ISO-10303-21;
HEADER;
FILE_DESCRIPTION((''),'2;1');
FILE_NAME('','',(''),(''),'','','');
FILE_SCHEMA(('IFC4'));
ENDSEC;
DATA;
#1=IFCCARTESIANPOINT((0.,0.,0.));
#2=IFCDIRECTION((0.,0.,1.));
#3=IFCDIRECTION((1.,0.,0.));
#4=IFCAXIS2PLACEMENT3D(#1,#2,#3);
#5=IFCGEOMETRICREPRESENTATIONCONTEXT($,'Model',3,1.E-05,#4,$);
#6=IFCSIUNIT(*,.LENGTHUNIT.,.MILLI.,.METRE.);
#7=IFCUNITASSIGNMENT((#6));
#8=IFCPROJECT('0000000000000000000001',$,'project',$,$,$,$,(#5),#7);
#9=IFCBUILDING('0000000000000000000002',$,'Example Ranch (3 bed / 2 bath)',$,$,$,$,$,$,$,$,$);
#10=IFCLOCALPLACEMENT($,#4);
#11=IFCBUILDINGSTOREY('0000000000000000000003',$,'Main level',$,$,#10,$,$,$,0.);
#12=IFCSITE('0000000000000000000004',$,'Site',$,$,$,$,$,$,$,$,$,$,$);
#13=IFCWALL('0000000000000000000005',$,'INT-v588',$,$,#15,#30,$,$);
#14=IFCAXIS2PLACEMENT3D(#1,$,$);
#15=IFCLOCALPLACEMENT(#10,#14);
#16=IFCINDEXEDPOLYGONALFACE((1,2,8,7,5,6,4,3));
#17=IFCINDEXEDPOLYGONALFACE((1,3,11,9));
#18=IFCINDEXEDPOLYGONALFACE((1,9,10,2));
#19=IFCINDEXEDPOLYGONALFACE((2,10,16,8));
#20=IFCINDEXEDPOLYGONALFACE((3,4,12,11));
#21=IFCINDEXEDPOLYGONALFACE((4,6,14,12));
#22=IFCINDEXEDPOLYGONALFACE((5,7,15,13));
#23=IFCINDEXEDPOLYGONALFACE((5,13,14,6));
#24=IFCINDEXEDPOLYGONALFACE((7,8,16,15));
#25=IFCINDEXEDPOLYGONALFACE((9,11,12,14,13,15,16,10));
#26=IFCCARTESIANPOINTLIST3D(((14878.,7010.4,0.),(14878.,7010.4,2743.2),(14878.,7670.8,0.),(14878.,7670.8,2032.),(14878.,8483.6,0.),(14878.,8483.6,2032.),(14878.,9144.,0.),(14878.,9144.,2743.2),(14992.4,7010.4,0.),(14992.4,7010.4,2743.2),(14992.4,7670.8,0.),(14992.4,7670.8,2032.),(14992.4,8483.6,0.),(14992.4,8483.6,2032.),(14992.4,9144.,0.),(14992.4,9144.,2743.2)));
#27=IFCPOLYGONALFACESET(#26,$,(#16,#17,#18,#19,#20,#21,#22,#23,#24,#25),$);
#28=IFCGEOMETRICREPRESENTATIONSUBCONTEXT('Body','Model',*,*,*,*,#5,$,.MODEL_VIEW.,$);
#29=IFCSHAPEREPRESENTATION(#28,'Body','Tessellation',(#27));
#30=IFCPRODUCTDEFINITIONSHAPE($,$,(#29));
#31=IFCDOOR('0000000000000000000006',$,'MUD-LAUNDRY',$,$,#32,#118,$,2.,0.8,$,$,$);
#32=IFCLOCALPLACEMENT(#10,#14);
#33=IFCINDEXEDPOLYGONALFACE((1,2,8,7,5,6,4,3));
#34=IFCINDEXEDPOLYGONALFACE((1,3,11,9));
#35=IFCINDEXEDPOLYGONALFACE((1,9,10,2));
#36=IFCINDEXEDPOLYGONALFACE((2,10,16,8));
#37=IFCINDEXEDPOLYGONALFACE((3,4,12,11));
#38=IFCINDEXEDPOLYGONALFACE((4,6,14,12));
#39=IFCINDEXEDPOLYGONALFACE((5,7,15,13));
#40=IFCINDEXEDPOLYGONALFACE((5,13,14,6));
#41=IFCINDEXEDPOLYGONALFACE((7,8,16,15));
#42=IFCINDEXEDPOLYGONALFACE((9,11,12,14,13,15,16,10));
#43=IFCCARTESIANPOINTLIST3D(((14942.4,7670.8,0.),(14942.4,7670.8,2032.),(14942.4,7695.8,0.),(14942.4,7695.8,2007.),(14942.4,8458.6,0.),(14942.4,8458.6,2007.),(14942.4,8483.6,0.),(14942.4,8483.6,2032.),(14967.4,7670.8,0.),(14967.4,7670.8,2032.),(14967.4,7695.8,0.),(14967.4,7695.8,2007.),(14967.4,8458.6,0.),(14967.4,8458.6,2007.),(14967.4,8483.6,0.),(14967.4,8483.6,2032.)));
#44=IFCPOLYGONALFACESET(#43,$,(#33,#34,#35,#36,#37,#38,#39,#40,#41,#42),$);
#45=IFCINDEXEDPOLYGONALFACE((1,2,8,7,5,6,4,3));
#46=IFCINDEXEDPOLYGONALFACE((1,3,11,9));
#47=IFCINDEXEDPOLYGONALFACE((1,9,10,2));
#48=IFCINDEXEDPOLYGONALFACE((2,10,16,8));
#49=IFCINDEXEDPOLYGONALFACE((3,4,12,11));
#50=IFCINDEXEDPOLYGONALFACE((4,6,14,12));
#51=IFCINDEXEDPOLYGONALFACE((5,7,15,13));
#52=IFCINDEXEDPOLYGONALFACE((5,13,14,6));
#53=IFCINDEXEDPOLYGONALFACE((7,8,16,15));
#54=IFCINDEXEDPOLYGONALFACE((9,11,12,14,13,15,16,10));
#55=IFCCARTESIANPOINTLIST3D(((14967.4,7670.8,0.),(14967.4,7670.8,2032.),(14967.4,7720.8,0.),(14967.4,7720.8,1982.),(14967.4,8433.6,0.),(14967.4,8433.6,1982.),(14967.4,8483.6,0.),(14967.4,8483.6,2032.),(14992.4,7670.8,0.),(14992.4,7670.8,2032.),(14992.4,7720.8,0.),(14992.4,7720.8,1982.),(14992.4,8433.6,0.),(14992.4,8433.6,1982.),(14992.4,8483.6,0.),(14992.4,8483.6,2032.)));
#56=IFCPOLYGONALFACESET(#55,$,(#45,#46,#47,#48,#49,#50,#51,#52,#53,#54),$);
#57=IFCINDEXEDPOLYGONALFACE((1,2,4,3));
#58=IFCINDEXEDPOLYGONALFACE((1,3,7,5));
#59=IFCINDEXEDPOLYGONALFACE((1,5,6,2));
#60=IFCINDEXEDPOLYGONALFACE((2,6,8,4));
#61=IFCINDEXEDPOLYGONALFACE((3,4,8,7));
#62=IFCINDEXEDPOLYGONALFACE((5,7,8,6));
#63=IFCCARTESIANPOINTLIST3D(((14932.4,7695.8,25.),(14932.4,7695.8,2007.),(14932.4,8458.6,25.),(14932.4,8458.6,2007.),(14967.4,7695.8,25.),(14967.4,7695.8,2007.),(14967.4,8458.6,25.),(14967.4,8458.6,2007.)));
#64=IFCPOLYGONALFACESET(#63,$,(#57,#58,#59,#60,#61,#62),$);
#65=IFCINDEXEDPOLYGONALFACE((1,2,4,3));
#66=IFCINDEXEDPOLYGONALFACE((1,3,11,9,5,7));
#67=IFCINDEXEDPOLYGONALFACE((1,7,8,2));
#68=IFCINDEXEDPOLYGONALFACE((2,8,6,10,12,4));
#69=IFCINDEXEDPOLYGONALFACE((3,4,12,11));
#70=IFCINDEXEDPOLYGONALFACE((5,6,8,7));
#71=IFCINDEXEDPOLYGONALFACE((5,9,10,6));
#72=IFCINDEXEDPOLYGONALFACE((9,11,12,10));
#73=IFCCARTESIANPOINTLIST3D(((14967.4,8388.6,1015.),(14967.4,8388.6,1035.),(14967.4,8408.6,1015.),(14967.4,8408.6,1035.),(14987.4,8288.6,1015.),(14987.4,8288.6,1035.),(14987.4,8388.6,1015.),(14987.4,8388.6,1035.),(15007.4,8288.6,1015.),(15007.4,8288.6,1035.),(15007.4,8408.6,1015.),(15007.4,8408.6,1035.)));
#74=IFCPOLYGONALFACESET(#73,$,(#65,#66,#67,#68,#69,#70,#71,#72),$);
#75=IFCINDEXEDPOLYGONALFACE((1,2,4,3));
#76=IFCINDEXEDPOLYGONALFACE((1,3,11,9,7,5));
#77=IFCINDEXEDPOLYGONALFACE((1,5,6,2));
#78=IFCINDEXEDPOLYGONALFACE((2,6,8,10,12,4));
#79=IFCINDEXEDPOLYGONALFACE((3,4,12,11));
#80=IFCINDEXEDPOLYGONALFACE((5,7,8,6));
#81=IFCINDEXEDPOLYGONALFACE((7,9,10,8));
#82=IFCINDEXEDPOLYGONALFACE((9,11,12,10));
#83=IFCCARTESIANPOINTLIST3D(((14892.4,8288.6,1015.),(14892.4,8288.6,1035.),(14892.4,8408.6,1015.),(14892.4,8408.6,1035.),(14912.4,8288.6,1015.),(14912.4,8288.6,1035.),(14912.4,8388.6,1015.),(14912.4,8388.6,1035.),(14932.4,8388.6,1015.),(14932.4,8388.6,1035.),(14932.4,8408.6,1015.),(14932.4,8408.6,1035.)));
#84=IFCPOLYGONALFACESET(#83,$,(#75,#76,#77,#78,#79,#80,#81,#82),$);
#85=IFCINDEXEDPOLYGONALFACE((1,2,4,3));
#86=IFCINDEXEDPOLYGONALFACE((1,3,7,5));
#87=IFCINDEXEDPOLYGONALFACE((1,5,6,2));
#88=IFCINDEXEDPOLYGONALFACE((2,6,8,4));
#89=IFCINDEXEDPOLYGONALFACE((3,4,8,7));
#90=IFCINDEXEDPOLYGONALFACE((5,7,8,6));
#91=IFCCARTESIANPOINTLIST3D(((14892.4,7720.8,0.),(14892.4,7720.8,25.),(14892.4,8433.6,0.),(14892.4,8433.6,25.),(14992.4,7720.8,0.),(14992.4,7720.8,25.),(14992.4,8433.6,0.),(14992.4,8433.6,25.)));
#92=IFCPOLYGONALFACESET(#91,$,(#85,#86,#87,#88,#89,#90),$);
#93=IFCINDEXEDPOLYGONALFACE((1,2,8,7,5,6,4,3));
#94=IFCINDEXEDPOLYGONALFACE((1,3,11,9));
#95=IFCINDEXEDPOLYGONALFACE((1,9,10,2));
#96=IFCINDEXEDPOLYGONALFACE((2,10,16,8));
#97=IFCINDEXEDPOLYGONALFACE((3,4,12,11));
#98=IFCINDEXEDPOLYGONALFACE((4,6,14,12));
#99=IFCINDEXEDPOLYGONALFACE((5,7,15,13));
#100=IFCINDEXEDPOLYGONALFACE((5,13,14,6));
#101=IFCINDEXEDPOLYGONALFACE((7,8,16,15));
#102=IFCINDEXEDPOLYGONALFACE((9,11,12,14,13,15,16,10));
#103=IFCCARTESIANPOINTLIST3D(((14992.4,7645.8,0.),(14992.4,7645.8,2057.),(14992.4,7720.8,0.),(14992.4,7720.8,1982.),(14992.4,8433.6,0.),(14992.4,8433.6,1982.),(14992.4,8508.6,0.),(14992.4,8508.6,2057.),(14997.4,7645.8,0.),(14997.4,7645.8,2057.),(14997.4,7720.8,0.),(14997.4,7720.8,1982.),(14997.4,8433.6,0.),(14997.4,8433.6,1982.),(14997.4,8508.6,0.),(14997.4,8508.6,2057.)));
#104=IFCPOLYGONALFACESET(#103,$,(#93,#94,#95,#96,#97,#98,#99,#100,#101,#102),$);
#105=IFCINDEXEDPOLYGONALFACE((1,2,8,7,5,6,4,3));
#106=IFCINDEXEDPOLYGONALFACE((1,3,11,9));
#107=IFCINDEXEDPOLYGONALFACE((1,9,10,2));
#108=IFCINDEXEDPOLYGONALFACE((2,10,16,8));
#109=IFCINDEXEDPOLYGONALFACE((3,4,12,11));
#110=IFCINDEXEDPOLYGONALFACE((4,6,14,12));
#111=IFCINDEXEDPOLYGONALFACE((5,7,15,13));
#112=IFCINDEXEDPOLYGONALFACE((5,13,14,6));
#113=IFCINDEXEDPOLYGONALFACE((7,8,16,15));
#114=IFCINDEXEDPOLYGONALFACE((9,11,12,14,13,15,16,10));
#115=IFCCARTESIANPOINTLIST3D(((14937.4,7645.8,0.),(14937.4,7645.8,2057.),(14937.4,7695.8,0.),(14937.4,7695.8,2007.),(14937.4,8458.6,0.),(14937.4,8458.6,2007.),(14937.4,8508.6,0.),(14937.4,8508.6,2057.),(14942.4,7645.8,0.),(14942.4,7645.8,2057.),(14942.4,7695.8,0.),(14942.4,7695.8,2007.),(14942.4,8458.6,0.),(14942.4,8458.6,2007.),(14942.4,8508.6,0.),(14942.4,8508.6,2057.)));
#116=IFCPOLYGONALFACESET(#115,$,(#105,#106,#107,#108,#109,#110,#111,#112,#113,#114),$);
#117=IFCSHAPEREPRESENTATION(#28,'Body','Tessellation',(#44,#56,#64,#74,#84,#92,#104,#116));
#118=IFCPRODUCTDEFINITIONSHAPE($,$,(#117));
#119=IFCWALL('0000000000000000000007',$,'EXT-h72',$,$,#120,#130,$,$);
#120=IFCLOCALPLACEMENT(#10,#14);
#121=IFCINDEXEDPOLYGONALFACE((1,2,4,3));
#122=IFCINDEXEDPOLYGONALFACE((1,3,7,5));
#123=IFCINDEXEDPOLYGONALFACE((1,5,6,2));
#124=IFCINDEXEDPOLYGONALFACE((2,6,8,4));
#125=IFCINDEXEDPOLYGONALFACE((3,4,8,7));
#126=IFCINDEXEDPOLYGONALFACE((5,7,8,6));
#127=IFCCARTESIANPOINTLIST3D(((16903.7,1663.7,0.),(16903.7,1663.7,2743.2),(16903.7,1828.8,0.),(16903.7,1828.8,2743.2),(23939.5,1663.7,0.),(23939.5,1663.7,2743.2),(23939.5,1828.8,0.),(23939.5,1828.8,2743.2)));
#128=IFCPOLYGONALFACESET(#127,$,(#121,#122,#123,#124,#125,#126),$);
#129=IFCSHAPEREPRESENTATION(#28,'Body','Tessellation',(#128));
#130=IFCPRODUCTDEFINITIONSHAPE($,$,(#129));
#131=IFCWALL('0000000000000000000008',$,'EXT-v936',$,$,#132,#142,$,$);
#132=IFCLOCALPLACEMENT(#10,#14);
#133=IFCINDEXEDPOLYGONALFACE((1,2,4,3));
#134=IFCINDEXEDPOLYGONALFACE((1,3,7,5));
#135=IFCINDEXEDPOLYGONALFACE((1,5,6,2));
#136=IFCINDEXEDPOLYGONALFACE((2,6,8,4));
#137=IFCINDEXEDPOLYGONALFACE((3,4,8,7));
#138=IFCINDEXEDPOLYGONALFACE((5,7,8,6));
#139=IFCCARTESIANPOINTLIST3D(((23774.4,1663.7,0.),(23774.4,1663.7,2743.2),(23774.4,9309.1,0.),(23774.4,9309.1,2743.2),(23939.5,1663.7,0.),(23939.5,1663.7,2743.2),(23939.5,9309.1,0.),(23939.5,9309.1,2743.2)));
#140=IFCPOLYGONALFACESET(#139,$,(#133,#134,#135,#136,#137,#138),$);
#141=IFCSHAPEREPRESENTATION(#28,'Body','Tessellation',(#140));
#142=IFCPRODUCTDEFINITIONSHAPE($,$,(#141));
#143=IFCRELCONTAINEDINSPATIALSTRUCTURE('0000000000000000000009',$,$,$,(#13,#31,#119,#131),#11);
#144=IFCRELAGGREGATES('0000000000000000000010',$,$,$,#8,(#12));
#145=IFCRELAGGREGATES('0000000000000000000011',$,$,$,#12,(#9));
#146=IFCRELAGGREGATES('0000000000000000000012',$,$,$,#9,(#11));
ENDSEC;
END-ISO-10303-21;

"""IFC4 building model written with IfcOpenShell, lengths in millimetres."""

from ifc_helpers import new_model, si_unit, frame, origin_with_axes, place, context, subcontext, project, spatial, line, indexed_curve, outline, extrude, element, fill, save


model = new_model("IFC4")

# Units and contexts
model_context = context("Model", 3, precision=1e-05, world=origin_with_axes())
body_context = subcontext(model_context, "Body", "Model", "MODEL_VIEW")
ifc_project = project(units=[si_unit("LENGTHUNIT", "METRE", prefix="MILLI")], contexts=[model_context])

# Site, building, storey
site = spatial("IfcSite", under=ifc_project, Name="Site")
building = spatial("IfcBuilding", under=site, Name="Example Ranch (3 bed / 2 bath)")
storey_placement = place(None, origin_with_axes())
storey = spatial("IfcBuildingStorey", under=building, at=storey_placement, Name="Main level", Elevation=0.0)

# Wall, opening, door
wall_1_placement = place(storey_placement, frame((14992.4, 7010.4, 0.0), z_axis=(0.0, 0.0, 1.0), x_axis=(0.0, 1.0, 0.0)))
wall_1 = element("IfcWall", 1, at=wall_1_placement, inside=storey, Name="INT-v588", context=body_context, shape_type="SweptSolid", body=[
    extrude(outline(indexed_curve([(0.0, 0.0), (0.0, 114.3), (2133.6, 114.3), (2133.6, 0.0), (0.0, 0.0)], self_intersect=False)), origin_with_axes(), (0.0, 0.0, 1.0), 2743.2),
])
opening_1_placement = place(wall_1_placement, frame((660.4, 0.0, 0.0), z_axis=(0.0, 0.0, 1.0), x_axis=(1.0, 0.0, 0.0)))
opening_1 = element("IfcOpeningElement", 2, at=opening_1_placement, cuts=wall_1, context=body_context, shape_type="SweptSolid", body=[
    extrude(outline(indexed_curve([(0.0, 0.0), (0.0, 114.3), (812.8, 114.3), (812.8, 0.0), (0.0, 0.0)], self_intersect=False)), origin_with_axes(), (0.0, 0.0, 1.0), 2032.0),
])
door_1_placement = place(storey_placement, frame((14992.4, 7670.8, 0.0), z_axis=(0.0, 0.0, 1.0), x_axis=(0.0, 1.0, 0.0)))
door_1 = element("IfcDoor", 3, at=door_1_placement, inside=storey, Name="MUD-LAUNDRY", OverallHeight=2.0, OverallWidth=0.8, context=body_context, shape_type="SweptSolid", body=[
    extrude(outline(indexed_curve([(0.0, 0.0), (0.0, 2032.0), (812.8, 2032.0), (812.8, 0.0), (787.8, 0.0), (787.8, 2007.0), (25.0, 2007.0), (25.0, 0.0)], segments=[line(1, 2, 3, 4, 5, 6, 7, 8, 1)])), frame((0.0, 25.0, 0.0), z_axis=(0.0, -1.0, 0.0), x_axis=(1.0, 0.0, 0.0)), (0.0, 0.0, -1.0), 25.0),
    extrude(outline(indexed_curve([(0.0, 0.0), (0.0, 2032.0), (812.8, 2032.0), (812.8, 0.0), (762.8, 0.0), (762.8, 1982.0), (50.0, 1982.0), (50.0, 0.0)], segments=[line(1, 2, 3, 4, 5, 6, 7, 8, 1)])), frame((0.0, 0.0, 0.0), z_axis=(0.0, -1.0, 0.0), x_axis=(1.0, 0.0, 0.0)), (0.0, 0.0, -1.0), 25.0),
    extrude(outline(indexed_curve([(0.0, 0.0), (762.8, 0.0), (762.8, 35.0), (0.0, 35.0)], segments=[line(1, 2, 3, 4, 1)])), frame((25.0, 25.0, 25.0), z_axis=(0.0, 0.0, 1.0), x_axis=(1.0, 0.0, 0.0)), (0.0, 0.0, 1.0), 1982.0),
    extrude(outline(indexed_curve([(0.0, 0.0), (0.0, -40.0), (-120.0, -40.0), (-120.0, -20.0), (-20.0, -20.0), (-20.0, 0.0)], segments=[line(1, 2, 3, 4, 5, 6, 1)])), frame((737.8, 25.0, 1015.0), z_axis=(0.0, 0.0, 1.0), x_axis=(1.0, 0.0, 0.0)), (0.0, 0.0, 1.0), 20.0),
    extrude(outline(indexed_curve([(0.0, 0.0), (0.0, 40.0), (-120.0, 40.0), (-120.0, 20.0), (-20.0, 20.0), (-20.0, 0.0)], segments=[line(1, 2, 3, 4, 5, 6, 1)])), frame((737.8, 60.0, 1015.0), z_axis=(0.0, 0.0, 1.0), x_axis=(1.0, 0.0, 0.0)), (0.0, 0.0, 1.0), 20.0),
    extrude(outline(indexed_curve([(0.0, 0.0), (712.8, 0.0), (712.8, 100.0), (0.0, 100.0)], segments=[line(1, 2, 3, 4, 1)])), frame((50.0, 0.0, 0.0), z_axis=(0.0, 0.0, 1.0), x_axis=(1.0, 0.0, 0.0)), (0.0, 0.0, 1.0), 25.0),
    extrude(outline(indexed_curve([(0.0, 0.0), (0.0, 2057.0), (862.8, 2057.0), (862.8, 0.0), (787.8, 0.0), (787.8, 1982.0), (75.0, 1982.0), (75.0, 0.0)], segments=[line(1, 2, 3, 4, 5, 6, 7, 8, 1)])), frame((-25.0, -5.0, 0.0), z_axis=(0.0, -1.0, 0.0), x_axis=(1.0, 0.0, 0.0)), (0.0, 0.0, -1.0), 5.0),
    extrude(outline(indexed_curve([(0.0, 0.0), (0.0, 2057.0), (862.8, 2057.0), (862.8, 0.0), (812.8, 0.0), (812.8, 2007.0), (50.0, 2007.0), (50.0, 0.0)], segments=[line(1, 2, 3, 4, 5, 6, 7, 8, 1)])), frame((-25.0, 50.0, 0.0), z_axis=(0.0, -1.0, 0.0), x_axis=(1.0, 0.0, 0.0)), (0.0, 0.0, -1.0), 5.0),
])
fill(opening_1, door_1)

# Walls
wall_2_placement = place(storey_placement, frame((16903.7, 1663.7, 0.0), z_axis=(0.0, 0.0, 1.0), x_axis=(1.0, 0.0, 0.0)))
element("IfcWall", 4, at=wall_2_placement, inside=storey, Name="EXT-h72", context=body_context, shape_type="SweptSolid", body=[
    extrude(outline(indexed_curve([(0.0, 0.0), (0.0, 165.1), (7035.8, 165.1), (7035.8, 0.0), (0.0, 0.0)], self_intersect=False)), origin_with_axes(), (0.0, 0.0, 1.0), 2743.2),
])
wall_3_placement = place(storey_placement, frame((23939.5, 1663.7, 0.0), z_axis=(0.0, 0.0, 1.0), x_axis=(0.0, 1.0, 0.0)))
element("IfcWall", 5, at=wall_3_placement, inside=storey, Name="EXT-v936", context=body_context, shape_type="SweptSolid", body=[
    extrude(outline(indexed_curve([(0.0, 0.0), (0.0, 165.1), (7645.4, 165.1), (7645.4, 0.0), (0.0, 0.0)], self_intersect=False)), origin_with_axes(), (0.0, 0.0, 1.0), 2743.2),
])

save(model, "model.ifc")
